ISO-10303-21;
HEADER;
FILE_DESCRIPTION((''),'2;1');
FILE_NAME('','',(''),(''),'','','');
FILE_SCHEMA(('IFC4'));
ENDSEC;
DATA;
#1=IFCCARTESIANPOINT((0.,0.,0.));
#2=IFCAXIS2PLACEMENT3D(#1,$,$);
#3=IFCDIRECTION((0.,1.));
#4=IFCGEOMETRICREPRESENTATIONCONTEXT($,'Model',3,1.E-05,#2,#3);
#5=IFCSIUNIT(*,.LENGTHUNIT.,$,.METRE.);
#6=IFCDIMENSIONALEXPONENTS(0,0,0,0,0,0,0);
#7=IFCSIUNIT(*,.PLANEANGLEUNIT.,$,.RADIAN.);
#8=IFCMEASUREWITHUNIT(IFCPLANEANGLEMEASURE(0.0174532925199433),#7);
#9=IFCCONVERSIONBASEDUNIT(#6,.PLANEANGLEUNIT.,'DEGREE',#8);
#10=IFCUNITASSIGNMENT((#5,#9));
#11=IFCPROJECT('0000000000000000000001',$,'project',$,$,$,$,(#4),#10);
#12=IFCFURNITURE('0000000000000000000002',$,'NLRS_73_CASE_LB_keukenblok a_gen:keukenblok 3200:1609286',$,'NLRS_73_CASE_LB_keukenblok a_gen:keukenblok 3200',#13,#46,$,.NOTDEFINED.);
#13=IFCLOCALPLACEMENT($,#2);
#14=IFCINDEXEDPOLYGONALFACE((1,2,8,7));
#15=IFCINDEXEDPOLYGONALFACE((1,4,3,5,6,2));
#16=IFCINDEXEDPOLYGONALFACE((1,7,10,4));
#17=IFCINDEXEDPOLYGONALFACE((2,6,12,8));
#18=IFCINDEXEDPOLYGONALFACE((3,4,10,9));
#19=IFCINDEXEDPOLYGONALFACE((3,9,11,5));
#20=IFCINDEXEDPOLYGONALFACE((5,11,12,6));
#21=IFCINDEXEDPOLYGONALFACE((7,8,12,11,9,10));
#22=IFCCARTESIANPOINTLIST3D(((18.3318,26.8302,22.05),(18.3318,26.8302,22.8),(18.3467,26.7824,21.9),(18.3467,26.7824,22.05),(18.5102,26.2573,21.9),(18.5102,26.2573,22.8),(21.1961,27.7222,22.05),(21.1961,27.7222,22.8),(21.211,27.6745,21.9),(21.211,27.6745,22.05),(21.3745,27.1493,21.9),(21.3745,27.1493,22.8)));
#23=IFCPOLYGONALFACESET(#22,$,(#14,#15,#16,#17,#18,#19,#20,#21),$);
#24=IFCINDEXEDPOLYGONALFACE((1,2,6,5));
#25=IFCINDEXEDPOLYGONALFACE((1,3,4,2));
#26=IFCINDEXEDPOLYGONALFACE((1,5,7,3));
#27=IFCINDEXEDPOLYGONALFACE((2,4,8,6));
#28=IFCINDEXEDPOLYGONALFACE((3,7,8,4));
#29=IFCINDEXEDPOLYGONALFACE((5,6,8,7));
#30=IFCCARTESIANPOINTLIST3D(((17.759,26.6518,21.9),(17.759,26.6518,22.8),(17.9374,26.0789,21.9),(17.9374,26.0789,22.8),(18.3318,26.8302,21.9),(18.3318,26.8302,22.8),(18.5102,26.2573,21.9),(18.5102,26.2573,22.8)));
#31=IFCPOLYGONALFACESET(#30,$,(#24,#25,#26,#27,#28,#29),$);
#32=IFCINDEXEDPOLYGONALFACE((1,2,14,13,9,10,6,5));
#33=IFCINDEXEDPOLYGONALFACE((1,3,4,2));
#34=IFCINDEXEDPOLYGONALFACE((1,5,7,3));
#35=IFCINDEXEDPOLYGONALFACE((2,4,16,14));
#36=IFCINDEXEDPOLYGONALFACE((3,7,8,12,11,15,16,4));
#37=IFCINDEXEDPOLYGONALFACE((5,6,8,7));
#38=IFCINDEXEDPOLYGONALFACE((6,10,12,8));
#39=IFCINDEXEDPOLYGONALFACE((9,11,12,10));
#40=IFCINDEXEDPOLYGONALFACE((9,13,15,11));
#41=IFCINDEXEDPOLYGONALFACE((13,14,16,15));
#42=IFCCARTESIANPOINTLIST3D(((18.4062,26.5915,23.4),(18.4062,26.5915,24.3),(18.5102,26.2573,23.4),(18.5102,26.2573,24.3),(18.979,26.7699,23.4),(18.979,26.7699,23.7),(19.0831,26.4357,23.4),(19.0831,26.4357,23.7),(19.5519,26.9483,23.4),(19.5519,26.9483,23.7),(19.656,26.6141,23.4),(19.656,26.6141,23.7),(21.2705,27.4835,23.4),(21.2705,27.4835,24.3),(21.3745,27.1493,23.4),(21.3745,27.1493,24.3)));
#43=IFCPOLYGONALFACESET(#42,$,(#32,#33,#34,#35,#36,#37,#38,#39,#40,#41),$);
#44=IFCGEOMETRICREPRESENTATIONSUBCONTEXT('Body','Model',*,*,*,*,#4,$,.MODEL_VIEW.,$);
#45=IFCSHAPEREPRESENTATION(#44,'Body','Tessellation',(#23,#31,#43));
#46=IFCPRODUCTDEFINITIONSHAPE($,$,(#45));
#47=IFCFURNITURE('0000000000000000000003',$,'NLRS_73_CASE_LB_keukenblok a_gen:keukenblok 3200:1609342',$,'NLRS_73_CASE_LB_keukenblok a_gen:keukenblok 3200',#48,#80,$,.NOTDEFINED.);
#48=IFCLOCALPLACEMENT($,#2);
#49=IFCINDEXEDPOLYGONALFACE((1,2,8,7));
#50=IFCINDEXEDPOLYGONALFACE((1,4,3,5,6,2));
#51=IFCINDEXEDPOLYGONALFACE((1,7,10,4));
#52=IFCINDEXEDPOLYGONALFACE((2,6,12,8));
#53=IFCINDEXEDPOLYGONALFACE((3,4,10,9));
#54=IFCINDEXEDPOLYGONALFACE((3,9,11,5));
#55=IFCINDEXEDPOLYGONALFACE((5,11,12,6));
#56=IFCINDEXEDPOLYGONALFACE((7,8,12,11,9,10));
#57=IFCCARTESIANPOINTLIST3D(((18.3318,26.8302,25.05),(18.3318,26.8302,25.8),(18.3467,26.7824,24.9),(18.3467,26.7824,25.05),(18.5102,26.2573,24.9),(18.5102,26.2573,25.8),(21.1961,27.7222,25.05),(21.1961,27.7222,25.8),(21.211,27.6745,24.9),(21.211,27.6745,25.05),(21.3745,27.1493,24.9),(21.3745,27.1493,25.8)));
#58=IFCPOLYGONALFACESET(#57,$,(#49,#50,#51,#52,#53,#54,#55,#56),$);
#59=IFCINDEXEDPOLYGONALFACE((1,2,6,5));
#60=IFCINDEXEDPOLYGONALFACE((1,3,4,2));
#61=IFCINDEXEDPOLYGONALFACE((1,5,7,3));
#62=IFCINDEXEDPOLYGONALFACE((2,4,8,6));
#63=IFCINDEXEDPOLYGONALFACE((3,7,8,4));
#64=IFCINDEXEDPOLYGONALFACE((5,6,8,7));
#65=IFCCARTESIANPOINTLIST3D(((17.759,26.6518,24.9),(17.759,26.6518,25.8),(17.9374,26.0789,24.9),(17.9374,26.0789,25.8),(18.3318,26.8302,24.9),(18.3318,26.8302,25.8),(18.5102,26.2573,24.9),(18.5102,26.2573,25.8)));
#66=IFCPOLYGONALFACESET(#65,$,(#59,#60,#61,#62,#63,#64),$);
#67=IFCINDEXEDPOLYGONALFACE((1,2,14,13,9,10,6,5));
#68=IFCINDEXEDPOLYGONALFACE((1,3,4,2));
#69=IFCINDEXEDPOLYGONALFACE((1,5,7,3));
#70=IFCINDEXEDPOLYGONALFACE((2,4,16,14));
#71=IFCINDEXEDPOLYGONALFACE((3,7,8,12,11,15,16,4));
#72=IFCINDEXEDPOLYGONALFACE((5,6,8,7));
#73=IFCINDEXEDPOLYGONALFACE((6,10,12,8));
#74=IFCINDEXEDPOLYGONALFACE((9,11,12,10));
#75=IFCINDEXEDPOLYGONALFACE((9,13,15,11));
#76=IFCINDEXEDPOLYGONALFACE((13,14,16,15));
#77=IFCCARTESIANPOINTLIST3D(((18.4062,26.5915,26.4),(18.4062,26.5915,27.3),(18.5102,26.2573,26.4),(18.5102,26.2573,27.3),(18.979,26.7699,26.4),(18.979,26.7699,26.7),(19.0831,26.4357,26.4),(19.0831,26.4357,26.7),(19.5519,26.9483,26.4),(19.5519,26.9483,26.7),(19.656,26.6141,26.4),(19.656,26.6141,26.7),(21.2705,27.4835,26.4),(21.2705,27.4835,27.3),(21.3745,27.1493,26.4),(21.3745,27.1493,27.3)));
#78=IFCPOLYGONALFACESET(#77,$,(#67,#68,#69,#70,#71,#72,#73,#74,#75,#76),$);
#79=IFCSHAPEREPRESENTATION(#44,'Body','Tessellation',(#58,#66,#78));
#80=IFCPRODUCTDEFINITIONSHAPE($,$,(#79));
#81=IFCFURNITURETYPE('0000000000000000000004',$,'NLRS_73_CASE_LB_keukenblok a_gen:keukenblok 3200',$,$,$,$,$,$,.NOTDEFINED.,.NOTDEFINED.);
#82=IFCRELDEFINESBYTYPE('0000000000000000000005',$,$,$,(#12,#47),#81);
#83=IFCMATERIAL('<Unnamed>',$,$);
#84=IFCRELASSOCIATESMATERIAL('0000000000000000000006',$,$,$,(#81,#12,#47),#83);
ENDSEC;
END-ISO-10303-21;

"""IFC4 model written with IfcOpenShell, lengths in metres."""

from ifc_helpers import new_model, entity, si_unit, converted_unit, direction, frame, origin, place, context, subcontext, project, indexed_curve, outline, extrude, source, transform, mapped, material, type_object, element, save


model = new_model("IFC4")

# Units and contexts
model_context = context("Model", 3, precision=1e-05, world=origin(), true_north=direction((0.0, 1.0)))
body_context = subcontext(model_context, "Body", "Model", "MODEL_VIEW")
ifc_project = project(units=[si_unit("LENGTHUNIT", "METRE"), converted_unit("PLANEANGLEUNIT", "DEGREE", entity("IfcPlaneAngleMeasure", 0.0174532925199433), si_unit("PLANEANGLEUNIT", "RADIAN"), dimensions=[0, 0, 0, 0, 0, 0, 0])], contexts=[model_context])

# Shared definitions
ifc_material = material(Name="<Unnamed>")
placement_1 = place(None, frame((13.1348, 11.9886, 0.0), z_axis=(0.0, 0.0, 1.0), x_axis=(0.954771, 0.297342, 0.0)))
placement_2 = place(placement_1, origin())
placement_3 = place(placement_2, frame((0.0, 0.0, 21.9)))
placement_4 = place(placement_2, frame((0.0, 0.0, 24.9)))

# Furniture
furniture_type = type_object("IfcFurnitureType", Name="NLRS_73_CASE_LB_keukenblok a_gen:keukenblok 3200", AssemblyPlace="NOTDEFINED", PredefinedType="NOTDEFINED", material=ifc_material)
shared_shape_1 = source(origin(), body_context, "Body", "SweptSolid", [
    extrude(outline(indexed_curve([(-0.1667, -0.35), (0.3833, -0.35), (0.3833, 0.55), (-0.2167, 0.55), (-0.2167, -0.2), (-0.1667, -0.2), (-0.1667, -0.35)], self_intersect=False)), frame((0.0, -0.3833, 0.35), z_axis=(1.0, 0.0, 0.0), x_axis=(0.0, 1.0, 0.0)), (0.0, 0.0, 1.0), 3.0),
    extrude(outline(indexed_curve([(-0.3, -0.3), (0.3, -0.3), (0.3, 0.3), (-0.3, 0.3), (-0.3, -0.3)], self_intersect=False)), frame((3.3, -0.3, 0.0), z_axis=(0.0, 0.0, 1.0), x_axis=(-1.0, 0.0, 0.0)), (0.0, 0.0, 1.0), 0.9),
    extrude(outline(indexed_curve([(-0.6, -1.2), (0.3, -1.2), (0.3, -0.6), (0.0, -0.6), (0.0, 0.0), (0.3, 0.0), (0.3, 1.8), (-0.6, 1.8), (-0.6, -1.2)], self_intersect=False)), frame((1.8, -0.35, 1.8), z_axis=(0.0, 1.0, 0.0), x_axis=(0.0, 0.0, -1.0)), (0.0, 0.0, 1.0), 0.35),
])
placement_5 = place(placement_3, origin())
furniture_1_placement = place(placement_5, frame((12.375, 12.025, 0.0), z_axis=(0.0, 0.0, 1.0), x_axis=(-1.0, 0.0, 0.0)))
element("IfcFurniture", 1, at=furniture_1_placement, type_object=furniture_type, material=ifc_material, Name="NLRS_73_CASE_LB_keukenblok a_gen:keukenblok 3200:1609286", ObjectType="NLRS_73_CASE_LB_keukenblok a_gen:keukenblok 3200", PredefinedType="NOTDEFINED", context=body_context, shape_type="MappedRepresentation", body=[
    mapped(shared_shape_1, transform((0.0, 0.0, 0.0), scale=1.0)),
])
placement_6 = place(placement_4, origin())
furniture_2_placement = place(placement_6, frame((12.375, 12.025, 0.0), z_axis=(0.0, 0.0, 1.0), x_axis=(-1.0, 0.0, 0.0)))
element("IfcFurniture", 2, at=furniture_2_placement, type_object=furniture_type, material=ifc_material, Name="NLRS_73_CASE_LB_keukenblok a_gen:keukenblok 3200:1609342", ObjectType="NLRS_73_CASE_LB_keukenblok a_gen:keukenblok 3200", PredefinedType="NOTDEFINED", context=body_context, shape_type="MappedRepresentation", body=[
    mapped(shared_shape_1, transform((0.0, 0.0, 0.0), scale=1.0)),
])

save(model, "model.ifc")
